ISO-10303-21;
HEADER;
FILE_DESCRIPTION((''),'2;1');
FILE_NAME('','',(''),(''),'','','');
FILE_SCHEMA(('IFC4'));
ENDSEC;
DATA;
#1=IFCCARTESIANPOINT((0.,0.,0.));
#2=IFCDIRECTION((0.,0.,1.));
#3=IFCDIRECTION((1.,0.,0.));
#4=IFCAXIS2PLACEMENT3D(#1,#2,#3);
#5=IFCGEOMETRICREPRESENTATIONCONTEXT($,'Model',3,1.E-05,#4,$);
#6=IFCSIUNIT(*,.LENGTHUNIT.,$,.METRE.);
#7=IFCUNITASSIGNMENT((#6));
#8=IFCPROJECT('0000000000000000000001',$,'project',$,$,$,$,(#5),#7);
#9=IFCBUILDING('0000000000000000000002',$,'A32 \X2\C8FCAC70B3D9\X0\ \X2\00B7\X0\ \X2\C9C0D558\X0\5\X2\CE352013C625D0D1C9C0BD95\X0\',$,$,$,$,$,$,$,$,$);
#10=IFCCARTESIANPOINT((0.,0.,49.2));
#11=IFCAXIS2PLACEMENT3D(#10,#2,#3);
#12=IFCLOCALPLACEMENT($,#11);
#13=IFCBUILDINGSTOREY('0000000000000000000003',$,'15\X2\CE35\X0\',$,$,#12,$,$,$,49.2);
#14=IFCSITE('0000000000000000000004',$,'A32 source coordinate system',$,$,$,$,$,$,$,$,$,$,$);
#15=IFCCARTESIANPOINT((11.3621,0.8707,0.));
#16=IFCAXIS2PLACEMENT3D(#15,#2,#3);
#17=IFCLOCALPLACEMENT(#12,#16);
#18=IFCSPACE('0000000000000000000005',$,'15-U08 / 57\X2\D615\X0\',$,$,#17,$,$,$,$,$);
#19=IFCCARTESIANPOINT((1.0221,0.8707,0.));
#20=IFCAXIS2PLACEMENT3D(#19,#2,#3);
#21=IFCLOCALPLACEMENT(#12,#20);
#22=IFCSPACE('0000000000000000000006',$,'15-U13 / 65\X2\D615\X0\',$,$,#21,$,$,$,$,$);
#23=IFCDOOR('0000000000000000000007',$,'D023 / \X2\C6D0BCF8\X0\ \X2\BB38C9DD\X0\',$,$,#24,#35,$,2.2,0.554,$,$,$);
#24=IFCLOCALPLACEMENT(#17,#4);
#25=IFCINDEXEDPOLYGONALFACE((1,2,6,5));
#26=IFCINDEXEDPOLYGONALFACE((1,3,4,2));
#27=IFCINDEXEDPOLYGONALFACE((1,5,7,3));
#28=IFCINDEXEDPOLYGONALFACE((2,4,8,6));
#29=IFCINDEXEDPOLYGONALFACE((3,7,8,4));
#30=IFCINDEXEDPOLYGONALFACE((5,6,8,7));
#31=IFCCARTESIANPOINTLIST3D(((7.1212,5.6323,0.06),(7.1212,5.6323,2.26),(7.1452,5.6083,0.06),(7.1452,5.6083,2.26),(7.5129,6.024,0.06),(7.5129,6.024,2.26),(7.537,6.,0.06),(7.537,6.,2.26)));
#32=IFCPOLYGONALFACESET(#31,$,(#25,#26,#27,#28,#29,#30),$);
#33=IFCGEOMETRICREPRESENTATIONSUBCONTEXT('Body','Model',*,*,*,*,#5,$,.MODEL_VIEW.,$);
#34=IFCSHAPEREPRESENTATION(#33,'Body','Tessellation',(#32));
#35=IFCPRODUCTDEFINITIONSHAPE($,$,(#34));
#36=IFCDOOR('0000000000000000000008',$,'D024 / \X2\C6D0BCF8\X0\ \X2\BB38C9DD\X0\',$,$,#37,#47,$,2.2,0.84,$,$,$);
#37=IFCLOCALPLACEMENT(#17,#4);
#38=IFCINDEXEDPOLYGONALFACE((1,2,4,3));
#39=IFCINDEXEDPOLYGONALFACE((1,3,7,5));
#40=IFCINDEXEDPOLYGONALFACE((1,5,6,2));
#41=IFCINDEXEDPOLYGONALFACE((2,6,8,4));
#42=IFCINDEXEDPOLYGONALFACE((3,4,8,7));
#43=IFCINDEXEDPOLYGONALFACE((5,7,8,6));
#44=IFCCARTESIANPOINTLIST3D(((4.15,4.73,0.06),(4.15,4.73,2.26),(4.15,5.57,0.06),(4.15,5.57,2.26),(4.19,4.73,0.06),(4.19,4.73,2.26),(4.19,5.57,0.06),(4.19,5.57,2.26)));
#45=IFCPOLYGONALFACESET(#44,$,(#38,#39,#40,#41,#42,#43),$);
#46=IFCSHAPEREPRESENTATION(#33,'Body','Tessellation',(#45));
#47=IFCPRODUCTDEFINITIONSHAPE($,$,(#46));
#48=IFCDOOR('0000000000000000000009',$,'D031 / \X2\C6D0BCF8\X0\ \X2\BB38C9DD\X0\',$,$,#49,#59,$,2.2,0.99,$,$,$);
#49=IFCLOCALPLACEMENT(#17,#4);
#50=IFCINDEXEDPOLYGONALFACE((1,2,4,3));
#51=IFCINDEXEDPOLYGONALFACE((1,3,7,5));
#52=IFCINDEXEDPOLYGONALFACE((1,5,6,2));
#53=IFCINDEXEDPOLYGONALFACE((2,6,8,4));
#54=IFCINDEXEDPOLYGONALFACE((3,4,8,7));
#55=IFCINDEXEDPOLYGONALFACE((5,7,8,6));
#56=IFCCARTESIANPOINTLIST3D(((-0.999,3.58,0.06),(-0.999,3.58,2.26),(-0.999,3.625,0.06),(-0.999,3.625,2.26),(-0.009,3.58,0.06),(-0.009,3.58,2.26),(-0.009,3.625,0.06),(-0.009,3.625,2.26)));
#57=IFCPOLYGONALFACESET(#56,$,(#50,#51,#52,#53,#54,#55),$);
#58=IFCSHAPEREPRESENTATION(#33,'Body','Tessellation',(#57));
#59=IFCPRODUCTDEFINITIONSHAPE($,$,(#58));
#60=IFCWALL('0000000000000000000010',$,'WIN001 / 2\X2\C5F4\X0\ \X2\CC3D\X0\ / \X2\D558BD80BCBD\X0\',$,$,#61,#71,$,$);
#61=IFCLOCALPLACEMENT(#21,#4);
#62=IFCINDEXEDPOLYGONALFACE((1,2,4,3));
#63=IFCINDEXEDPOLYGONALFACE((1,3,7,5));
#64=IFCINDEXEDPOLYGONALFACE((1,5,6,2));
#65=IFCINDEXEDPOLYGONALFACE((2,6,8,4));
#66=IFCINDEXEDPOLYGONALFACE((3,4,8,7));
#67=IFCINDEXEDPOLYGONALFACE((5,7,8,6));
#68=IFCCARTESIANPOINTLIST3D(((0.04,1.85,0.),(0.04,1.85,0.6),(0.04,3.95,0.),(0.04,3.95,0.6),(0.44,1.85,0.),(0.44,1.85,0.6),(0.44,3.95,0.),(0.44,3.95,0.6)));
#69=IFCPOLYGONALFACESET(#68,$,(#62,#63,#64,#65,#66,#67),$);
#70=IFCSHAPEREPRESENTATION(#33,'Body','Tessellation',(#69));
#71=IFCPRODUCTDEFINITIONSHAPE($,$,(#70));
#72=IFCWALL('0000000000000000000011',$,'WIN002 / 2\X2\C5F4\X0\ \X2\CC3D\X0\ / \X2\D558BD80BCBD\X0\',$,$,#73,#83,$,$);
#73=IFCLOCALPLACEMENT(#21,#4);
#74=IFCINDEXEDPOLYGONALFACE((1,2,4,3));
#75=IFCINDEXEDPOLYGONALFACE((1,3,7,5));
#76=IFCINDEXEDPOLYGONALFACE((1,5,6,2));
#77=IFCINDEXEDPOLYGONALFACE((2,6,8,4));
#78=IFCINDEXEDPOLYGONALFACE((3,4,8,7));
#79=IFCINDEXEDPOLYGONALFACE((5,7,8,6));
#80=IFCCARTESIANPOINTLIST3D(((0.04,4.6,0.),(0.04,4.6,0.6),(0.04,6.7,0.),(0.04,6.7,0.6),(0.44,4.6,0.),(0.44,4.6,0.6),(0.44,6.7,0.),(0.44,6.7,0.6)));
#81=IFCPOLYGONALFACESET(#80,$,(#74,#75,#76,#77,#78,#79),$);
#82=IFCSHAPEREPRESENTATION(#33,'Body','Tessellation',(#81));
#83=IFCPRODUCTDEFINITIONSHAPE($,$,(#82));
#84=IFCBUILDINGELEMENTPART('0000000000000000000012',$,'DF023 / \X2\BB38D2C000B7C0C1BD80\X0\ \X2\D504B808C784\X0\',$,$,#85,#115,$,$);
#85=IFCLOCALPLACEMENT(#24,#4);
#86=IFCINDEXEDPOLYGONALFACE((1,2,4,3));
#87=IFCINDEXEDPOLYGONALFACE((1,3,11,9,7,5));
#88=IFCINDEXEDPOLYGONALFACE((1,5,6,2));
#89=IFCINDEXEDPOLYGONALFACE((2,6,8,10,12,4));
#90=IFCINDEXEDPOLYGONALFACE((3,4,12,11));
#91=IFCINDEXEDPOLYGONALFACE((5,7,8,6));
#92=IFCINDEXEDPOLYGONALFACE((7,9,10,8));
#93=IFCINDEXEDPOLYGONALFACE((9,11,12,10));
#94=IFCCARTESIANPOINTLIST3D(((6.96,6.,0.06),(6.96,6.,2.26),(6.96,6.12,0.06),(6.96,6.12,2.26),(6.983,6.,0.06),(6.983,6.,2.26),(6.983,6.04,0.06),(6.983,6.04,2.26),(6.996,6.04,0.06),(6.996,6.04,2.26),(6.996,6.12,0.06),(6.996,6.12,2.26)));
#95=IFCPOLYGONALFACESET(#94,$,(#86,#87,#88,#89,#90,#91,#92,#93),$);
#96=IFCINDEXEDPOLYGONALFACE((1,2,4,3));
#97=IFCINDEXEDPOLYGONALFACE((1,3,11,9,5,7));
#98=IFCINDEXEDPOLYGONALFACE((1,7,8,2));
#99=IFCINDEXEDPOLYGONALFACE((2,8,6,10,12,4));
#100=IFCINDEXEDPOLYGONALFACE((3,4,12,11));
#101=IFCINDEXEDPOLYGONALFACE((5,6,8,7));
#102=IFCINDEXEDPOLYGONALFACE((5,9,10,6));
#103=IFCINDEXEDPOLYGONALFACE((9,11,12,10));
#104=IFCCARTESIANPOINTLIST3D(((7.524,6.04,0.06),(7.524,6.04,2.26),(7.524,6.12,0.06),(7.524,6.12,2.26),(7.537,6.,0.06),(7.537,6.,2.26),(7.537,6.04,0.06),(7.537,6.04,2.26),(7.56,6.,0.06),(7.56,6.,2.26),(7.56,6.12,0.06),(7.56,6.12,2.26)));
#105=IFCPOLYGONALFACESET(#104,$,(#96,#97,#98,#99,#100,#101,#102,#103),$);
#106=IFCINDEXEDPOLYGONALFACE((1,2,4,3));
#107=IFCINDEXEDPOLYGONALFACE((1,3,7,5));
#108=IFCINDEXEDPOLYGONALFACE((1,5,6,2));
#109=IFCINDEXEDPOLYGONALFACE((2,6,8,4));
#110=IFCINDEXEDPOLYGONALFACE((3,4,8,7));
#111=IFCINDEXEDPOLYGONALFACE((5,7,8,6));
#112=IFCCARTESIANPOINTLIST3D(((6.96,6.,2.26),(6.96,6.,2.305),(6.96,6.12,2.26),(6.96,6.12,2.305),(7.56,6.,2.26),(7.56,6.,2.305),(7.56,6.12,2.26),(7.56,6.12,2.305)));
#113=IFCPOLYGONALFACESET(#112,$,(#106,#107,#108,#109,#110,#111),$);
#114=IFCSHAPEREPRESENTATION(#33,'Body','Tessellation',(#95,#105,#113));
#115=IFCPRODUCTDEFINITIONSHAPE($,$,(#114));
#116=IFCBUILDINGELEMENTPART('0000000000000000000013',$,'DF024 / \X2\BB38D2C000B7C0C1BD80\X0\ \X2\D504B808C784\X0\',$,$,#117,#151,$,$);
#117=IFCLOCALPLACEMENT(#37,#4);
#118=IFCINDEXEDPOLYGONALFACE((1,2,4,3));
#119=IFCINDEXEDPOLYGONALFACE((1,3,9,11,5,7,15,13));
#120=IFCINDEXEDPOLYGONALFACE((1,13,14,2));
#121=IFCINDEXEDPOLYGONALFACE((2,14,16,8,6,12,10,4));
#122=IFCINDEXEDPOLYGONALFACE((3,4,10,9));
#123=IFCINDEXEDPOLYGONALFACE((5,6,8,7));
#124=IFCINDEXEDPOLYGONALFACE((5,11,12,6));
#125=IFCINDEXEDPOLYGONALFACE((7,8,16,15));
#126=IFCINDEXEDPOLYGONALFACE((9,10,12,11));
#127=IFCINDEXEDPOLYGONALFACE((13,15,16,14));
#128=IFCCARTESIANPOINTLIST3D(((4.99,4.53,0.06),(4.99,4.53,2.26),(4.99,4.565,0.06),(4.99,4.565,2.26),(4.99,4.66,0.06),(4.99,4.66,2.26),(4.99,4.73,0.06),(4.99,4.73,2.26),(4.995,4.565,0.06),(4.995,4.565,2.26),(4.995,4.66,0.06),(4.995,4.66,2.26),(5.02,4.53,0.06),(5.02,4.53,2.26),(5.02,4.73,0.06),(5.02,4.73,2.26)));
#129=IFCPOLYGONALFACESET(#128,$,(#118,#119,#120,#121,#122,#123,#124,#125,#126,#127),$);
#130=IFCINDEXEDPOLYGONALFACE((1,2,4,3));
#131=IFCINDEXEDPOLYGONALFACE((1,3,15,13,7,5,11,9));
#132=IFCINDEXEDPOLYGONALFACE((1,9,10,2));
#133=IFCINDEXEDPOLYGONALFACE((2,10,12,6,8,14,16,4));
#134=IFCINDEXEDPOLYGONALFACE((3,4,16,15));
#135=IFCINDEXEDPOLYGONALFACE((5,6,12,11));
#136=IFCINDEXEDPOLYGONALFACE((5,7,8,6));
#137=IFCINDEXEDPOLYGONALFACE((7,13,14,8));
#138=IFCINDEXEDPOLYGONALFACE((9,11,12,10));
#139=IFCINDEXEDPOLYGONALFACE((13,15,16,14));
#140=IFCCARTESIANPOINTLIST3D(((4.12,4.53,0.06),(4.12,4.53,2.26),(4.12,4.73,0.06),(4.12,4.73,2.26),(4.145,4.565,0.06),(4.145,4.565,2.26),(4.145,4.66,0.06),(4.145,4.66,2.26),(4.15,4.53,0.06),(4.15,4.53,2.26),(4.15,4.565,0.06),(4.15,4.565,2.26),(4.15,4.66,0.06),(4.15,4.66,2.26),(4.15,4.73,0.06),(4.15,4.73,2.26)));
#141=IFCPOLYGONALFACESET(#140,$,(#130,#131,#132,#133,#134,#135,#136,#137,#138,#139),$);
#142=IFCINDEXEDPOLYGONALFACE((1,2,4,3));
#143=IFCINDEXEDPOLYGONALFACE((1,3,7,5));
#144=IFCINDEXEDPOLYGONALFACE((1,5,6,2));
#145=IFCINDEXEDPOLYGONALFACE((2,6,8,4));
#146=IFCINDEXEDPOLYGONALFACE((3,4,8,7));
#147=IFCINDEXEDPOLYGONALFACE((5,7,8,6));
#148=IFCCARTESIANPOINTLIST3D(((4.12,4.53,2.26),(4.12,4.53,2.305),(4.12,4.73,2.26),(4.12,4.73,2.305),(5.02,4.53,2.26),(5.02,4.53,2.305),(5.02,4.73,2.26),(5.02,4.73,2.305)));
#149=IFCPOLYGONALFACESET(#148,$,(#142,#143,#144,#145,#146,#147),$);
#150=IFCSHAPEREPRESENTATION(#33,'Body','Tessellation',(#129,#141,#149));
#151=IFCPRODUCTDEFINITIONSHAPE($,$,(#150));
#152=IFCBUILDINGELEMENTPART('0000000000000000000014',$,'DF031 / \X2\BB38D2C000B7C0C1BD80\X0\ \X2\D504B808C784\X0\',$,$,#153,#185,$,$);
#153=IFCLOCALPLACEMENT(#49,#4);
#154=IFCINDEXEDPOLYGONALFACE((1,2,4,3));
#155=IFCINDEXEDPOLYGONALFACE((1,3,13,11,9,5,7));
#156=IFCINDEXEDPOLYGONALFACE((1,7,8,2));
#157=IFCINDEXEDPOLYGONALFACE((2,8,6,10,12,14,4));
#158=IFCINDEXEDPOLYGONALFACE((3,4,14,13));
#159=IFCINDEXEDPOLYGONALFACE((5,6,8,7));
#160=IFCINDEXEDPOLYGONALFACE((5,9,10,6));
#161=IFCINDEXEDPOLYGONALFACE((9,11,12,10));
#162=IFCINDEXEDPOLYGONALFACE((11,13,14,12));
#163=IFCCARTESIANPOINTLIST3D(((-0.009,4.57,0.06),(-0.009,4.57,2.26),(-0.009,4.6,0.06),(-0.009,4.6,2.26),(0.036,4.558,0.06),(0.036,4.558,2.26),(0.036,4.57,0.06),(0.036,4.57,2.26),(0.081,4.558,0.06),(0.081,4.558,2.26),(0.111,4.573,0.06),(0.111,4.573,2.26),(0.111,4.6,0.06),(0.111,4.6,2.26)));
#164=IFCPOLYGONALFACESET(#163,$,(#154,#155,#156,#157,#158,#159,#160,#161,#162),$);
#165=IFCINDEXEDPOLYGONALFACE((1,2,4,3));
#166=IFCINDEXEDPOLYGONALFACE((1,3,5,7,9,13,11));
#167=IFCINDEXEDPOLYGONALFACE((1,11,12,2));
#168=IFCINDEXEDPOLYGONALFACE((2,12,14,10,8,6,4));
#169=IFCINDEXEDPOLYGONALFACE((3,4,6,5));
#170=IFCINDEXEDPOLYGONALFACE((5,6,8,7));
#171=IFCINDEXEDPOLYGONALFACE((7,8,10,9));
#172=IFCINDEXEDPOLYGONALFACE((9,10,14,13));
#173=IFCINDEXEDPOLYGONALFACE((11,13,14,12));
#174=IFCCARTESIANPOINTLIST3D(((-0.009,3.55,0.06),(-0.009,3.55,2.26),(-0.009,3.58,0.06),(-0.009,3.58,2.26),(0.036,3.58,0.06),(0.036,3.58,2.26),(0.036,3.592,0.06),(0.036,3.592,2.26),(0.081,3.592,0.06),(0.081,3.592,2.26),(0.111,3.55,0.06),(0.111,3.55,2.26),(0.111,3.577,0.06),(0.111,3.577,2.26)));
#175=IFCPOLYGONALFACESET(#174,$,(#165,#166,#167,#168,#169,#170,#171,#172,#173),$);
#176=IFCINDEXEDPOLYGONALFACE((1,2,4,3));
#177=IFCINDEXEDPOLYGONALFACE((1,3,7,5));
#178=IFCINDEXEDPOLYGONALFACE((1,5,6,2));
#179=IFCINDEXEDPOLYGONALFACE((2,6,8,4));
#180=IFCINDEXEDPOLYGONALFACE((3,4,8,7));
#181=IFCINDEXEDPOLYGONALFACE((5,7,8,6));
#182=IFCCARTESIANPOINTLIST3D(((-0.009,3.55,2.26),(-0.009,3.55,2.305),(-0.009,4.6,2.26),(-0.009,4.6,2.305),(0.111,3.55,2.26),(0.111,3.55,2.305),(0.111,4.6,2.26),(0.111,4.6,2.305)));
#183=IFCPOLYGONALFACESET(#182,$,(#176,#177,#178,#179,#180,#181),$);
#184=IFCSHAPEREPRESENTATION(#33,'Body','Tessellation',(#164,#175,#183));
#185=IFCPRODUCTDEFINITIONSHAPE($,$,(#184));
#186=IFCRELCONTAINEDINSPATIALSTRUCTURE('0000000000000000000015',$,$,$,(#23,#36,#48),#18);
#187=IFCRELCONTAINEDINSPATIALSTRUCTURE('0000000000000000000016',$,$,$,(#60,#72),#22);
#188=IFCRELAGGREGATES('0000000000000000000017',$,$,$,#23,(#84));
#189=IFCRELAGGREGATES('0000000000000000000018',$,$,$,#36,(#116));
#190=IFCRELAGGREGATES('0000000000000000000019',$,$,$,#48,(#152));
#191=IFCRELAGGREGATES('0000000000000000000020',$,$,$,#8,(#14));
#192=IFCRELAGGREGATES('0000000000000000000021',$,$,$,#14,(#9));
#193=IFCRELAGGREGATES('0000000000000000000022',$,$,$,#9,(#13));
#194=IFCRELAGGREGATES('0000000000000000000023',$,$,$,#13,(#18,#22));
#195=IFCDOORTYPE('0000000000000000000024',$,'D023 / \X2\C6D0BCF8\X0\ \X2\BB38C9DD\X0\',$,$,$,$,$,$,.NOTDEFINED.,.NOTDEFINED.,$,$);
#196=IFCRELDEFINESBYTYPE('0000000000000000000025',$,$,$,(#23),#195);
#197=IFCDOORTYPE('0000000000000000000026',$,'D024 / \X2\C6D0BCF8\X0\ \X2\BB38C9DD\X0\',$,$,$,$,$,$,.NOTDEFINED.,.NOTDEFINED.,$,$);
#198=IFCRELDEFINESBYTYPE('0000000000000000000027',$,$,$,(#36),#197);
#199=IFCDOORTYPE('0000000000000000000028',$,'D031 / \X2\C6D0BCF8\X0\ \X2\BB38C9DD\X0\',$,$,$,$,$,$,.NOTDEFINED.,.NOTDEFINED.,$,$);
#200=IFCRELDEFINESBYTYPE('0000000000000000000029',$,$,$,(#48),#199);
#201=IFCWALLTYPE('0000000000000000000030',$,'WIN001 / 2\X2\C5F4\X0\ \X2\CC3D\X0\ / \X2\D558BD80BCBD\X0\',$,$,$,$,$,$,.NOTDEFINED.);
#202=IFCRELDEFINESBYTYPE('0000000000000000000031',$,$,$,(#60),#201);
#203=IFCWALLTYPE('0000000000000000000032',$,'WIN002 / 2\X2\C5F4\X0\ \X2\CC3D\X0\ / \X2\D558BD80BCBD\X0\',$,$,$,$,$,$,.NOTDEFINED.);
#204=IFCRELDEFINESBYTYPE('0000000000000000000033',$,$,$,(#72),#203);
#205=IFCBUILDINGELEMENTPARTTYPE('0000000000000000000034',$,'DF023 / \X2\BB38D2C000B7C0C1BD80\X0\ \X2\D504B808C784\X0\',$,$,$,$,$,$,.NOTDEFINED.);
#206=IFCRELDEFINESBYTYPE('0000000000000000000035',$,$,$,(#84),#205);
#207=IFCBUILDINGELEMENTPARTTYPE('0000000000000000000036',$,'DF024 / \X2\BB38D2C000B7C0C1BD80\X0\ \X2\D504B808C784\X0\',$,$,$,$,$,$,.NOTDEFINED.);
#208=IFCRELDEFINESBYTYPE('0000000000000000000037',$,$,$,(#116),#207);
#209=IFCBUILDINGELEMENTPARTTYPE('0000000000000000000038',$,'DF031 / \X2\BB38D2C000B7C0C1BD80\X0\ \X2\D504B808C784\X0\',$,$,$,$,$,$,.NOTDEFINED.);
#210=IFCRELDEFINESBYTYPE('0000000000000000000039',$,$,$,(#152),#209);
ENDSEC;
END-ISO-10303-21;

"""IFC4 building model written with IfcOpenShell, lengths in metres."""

from ifc_helpers import new_model, si_unit, frame, origin, origin_with_axes, place, context, subcontext, project, spatial, polyline, outline, extrude, source, transform, mapped, type_object, type_shapes, element, aggregate, save


model = new_model("IFC4")

# Units and contexts
model_context = context("Model", 3, precision=1e-05, world=origin_with_axes())
body_context = subcontext(model_context, "Body", "Model", "MODEL_VIEW")
ifc_project = project(units=[si_unit("LENGTHUNIT", "METRE")], contexts=[model_context])

# Site, building, storey, space
site = spatial("IfcSite", under=ifc_project, Name="A32 source coordinate system")
building = spatial("IfcBuilding", under=site, Name="A32 주거동 · 지하5층–옥탑지붕")
storey_placement = place(None, frame((0.0, 0.0, 49.2), z_axis=(0.0, 0.0, 1.0), x_axis=(1.0, 0.0, 0.0)))
storey = spatial("IfcBuildingStorey", under=building, at=storey_placement, Name="15층", Elevation=49.2)
space_1_placement = place(storey_placement, frame((11.3621, 0.8707, 0.0), z_axis=(0.0, 0.0, 1.0), x_axis=(1.0, 0.0, 0.0)))
space_1 = spatial("IfcSpace", under=storey, at=space_1_placement, Name="15-U08 / 57형")

# Doors
door_type_1 = type_object("IfcDoorType", Name="D023 / 원본 문짝", OperationType="NOTDEFINED", PredefinedType="NOTDEFINED")
shared_shape_1 = source(origin(), body_context, "Body", "SweptSolid", [
    extrude(outline(polyline([(7.537, 6.0), (7.1452, 5.6083), (7.1212, 5.6323), (7.5129, 6.024), (7.537, 6.0)])), frame((0.0, 0.0, 0.06)), (0.0, 0.0, 1.0), 2.2),
])
type_shapes(door_type_1, [shared_shape_1])
door_1_placement = place(space_1_placement, origin_with_axes())
door_1 = element("IfcDoor", 1, at=door_1_placement, inside=space_1, type_object=door_type_1, Name="D023 / 원본 문짝", OverallHeight=2.2, OverallWidth=0.554, context=body_context, shape_type="MappedRepresentation", body=[
    mapped(shared_shape_1, transform((0.0, 0.0, 0.0), scale=1.0)),
])
door_type_2 = type_object("IfcDoorType", Name="D024 / 원본 문짝", OperationType="NOTDEFINED", PredefinedType="NOTDEFINED")
shared_shape_2 = source(origin(), body_context, "Body", "SweptSolid", [
    extrude(outline(polyline([(4.15, 4.73), (4.15, 5.57), (4.19, 5.57), (4.19, 4.73), (4.15, 4.73)])), frame((0.0, 0.0, 0.06)), (0.0, 0.0, 1.0), 2.2),
])
type_shapes(door_type_2, [shared_shape_2])
door_2_placement = place(space_1_placement, origin_with_axes())
door_2 = element("IfcDoor", 2, at=door_2_placement, inside=space_1, type_object=door_type_2, Name="D024 / 원본 문짝", OverallHeight=2.2, OverallWidth=0.84, context=body_context, shape_type="MappedRepresentation", body=[
    mapped(shared_shape_2, transform((0.0, 0.0, 0.0), scale=1.0)),
])
door_type_3 = type_object("IfcDoorType", Name="D031 / 원본 문짝", OperationType="NOTDEFINED", PredefinedType="NOTDEFINED")
shared_shape_3 = source(origin(), body_context, "Body", "SweptSolid", [
    extrude(outline(polyline([(-0.009, 3.58), (-0.999, 3.58), (-0.999, 3.625), (-0.009, 3.625), (-0.009, 3.58)])), frame((0.0, 0.0, 0.06)), (0.0, 0.0, 1.0), 2.2),
])
type_shapes(door_type_3, [shared_shape_3])
door_3_placement = place(space_1_placement, origin_with_axes())
door_3 = element("IfcDoor", 3, at=door_3_placement, inside=space_1, type_object=door_type_3, Name="D031 / 원본 문짝", OverallHeight=2.2, OverallWidth=0.99, context=body_context, shape_type="MappedRepresentation", body=[
    mapped(shared_shape_3, transform((0.0, 0.0, 0.0), scale=1.0)),
])

# Shared definitions
space_2_placement = place(storey_placement, frame((1.0221, 0.8707, 0.0), z_axis=(0.0, 0.0, 1.0), x_axis=(1.0, 0.0, 0.0)))
space_2 = spatial("IfcSpace", under=storey, at=space_2_placement, Name="15-U13 / 65형")

# Walls
wall_type_1 = type_object("IfcWallType", Name="WIN001 / 2열 창 / 하부벽", PredefinedType="NOTDEFINED")
shared_shape_4 = source(origin(), body_context, "Body", "SweptSolid", [
    extrude(outline(polyline([(0.04, 3.95), (0.44, 3.95), (0.44, 1.85), (0.04, 1.85), (0.04, 3.95)])), origin(), (0.0, 0.0, 1.0), 0.6),
])
type_shapes(wall_type_1, [shared_shape_4])
wall_1_placement = place(space_2_placement, origin_with_axes())
element("IfcWall", 4, at=wall_1_placement, inside=space_2, type_object=wall_type_1, Name="WIN001 / 2열 창 / 하부벽", context=body_context, shape_type="MappedRepresentation", body=[
    mapped(shared_shape_4, transform((0.0, 0.0, 0.0), scale=1.0)),
])
wall_type_2 = type_object("IfcWallType", Name="WIN002 / 2열 창 / 하부벽", PredefinedType="NOTDEFINED")
shared_shape_5 = source(origin(), body_context, "Body", "SweptSolid", [
    extrude(outline(polyline([(0.04, 6.7), (0.44, 6.7), (0.44, 4.6), (0.04, 4.6), (0.04, 6.7)])), origin(), (0.0, 0.0, 1.0), 0.6),
])
type_shapes(wall_type_2, [shared_shape_5])
wall_2_placement = place(space_2_placement, origin_with_axes())
element("IfcWall", 5, at=wall_2_placement, inside=space_2, type_object=wall_type_2, Name="WIN002 / 2열 창 / 하부벽", context=body_context, shape_type="MappedRepresentation", body=[
    mapped(shared_shape_5, transform((0.0, 0.0, 0.0), scale=1.0)),
])

# Building element parts
building_element_part_type_1 = type_object("IfcBuildingElementPartType", Name="DF023 / 문틀·상부 프레임", PredefinedType="NOTDEFINED")
shared_shape_6 = source(origin(), body_context, "Body", "SweptSolid", [
    extrude(outline(polyline([(6.996, 6.12), (6.996, 6.04), (6.983, 6.04), (6.983, 6.0), (6.96, 6.0), (6.96, 6.12), (6.996, 6.12)])), frame((0.0, 0.0, 0.06)), (0.0, 0.0, 1.0), 2.2),
    extrude(outline(polyline([(7.56, 6.0), (7.537, 6.0), (7.537, 6.04), (7.524, 6.04), (7.524, 6.12), (7.56, 6.12), (7.56, 6.0)])), frame((0.0, 0.0, 0.06)), (0.0, 0.0, 1.0), 2.2),
    extrude(outline(polyline([(6.96, 6.0), (6.96, 6.12), (7.56, 6.12), (7.56, 6.0), (6.96, 6.0)])), frame((0.0, 0.0, 2.26)), (0.0, 0.0, 1.0), 0.045),
])
type_shapes(building_element_part_type_1, [shared_shape_6])
building_element_part_1_placement = place(door_1_placement, origin_with_axes())
building_element_part_1 = element("IfcBuildingElementPart", 6, at=building_element_part_1_placement, type_object=building_element_part_type_1, Name="DF023 / 문틀·상부 프레임", context=body_context, shape_type="MappedRepresentation", body=[
    mapped(shared_shape_6, transform((0.0, 0.0, 0.0), scale=1.0)),
])
aggregate(door_1, [building_element_part_1])
building_element_part_type_2 = type_object("IfcBuildingElementPartType", Name="DF024 / 문틀·상부 프레임", PredefinedType="NOTDEFINED")
shared_shape_7 = source(origin(), body_context, "Body", "SweptSolid", [
    extrude(outline(polyline([(5.02, 4.53), (4.99, 4.53), (4.99, 4.565), (4.995, 4.565), (4.995, 4.66), (4.99, 4.66), (4.99, 4.73), (5.02, 4.73), (5.02, 4.53)])), frame((0.0, 0.0, 0.06)), (0.0, 0.0, 1.0), 2.2),
    extrude(outline(polyline([(4.15, 4.73), (4.15, 4.66), (4.145, 4.66), (4.145, 4.565), (4.15, 4.565), (4.15, 4.53), (4.12, 4.53), (4.12, 4.73), (4.15, 4.73)])), frame((0.0, 0.0, 0.06)), (0.0, 0.0, 1.0), 2.2),
    extrude(outline(polyline([(4.12, 4.53), (4.12, 4.73), (5.02, 4.73), (5.02, 4.53), (4.12, 4.53)])), frame((0.0, 0.0, 2.26)), (0.0, 0.0, 1.0), 0.045),
])
type_shapes(building_element_part_type_2, [shared_shape_7])
building_element_part_2_placement = place(door_2_placement, origin_with_axes())
building_element_part_2 = element("IfcBuildingElementPart", 7, at=building_element_part_2_placement, type_object=building_element_part_type_2, Name="DF024 / 문틀·상부 프레임", context=body_context, shape_type="MappedRepresentation", body=[
    mapped(shared_shape_7, transform((0.0, 0.0, 0.0), scale=1.0)),
])
aggregate(door_2, [building_element_part_2])
building_element_part_type_3 = type_object("IfcBuildingElementPartType", Name="DF031 / 문틀·상부 프레임", PredefinedType="NOTDEFINED")
shared_shape_8 = source(origin(), body_context, "Body", "SweptSolid", [
    extrude(outline(polyline([(0.111, 4.6), (0.111, 4.573), (0.081, 4.558), (0.036, 4.558), (0.036, 4.57), (-0.009, 4.57), (-0.009, 4.6), (0.111, 4.6)])), frame((0.0, 0.0, 0.06)), (0.0, 0.0, 1.0), 2.2),
    extrude(outline(polyline([(-0.009, 3.58), (0.036, 3.58), (0.036, 3.592), (0.081, 3.592), (0.111, 3.577), (0.111, 3.55), (-0.009, 3.55), (-0.009, 3.58)])), frame((0.0, 0.0, 0.06)), (0.0, 0.0, 1.0), 2.2),
    extrude(outline(polyline([(-0.009, 3.55), (-0.009, 4.6), (0.111, 4.6), (0.111, 3.55), (-0.009, 3.55)])), frame((0.0, 0.0, 2.26)), (0.0, 0.0, 1.0), 0.045),
])
type_shapes(building_element_part_type_3, [shared_shape_8])
building_element_part_3_placement = place(door_3_placement, origin_with_axes())
building_element_part_3 = element("IfcBuildingElementPart", 8, at=building_element_part_3_placement, type_object=building_element_part_type_3, Name="DF031 / 문틀·상부 프레임", context=body_context, shape_type="MappedRepresentation", body=[
    mapped(shared_shape_8, transform((0.0, 0.0, 0.0), scale=1.0)),
])
aggregate(door_3, [building_element_part_3])

save(model, "model.ifc")
